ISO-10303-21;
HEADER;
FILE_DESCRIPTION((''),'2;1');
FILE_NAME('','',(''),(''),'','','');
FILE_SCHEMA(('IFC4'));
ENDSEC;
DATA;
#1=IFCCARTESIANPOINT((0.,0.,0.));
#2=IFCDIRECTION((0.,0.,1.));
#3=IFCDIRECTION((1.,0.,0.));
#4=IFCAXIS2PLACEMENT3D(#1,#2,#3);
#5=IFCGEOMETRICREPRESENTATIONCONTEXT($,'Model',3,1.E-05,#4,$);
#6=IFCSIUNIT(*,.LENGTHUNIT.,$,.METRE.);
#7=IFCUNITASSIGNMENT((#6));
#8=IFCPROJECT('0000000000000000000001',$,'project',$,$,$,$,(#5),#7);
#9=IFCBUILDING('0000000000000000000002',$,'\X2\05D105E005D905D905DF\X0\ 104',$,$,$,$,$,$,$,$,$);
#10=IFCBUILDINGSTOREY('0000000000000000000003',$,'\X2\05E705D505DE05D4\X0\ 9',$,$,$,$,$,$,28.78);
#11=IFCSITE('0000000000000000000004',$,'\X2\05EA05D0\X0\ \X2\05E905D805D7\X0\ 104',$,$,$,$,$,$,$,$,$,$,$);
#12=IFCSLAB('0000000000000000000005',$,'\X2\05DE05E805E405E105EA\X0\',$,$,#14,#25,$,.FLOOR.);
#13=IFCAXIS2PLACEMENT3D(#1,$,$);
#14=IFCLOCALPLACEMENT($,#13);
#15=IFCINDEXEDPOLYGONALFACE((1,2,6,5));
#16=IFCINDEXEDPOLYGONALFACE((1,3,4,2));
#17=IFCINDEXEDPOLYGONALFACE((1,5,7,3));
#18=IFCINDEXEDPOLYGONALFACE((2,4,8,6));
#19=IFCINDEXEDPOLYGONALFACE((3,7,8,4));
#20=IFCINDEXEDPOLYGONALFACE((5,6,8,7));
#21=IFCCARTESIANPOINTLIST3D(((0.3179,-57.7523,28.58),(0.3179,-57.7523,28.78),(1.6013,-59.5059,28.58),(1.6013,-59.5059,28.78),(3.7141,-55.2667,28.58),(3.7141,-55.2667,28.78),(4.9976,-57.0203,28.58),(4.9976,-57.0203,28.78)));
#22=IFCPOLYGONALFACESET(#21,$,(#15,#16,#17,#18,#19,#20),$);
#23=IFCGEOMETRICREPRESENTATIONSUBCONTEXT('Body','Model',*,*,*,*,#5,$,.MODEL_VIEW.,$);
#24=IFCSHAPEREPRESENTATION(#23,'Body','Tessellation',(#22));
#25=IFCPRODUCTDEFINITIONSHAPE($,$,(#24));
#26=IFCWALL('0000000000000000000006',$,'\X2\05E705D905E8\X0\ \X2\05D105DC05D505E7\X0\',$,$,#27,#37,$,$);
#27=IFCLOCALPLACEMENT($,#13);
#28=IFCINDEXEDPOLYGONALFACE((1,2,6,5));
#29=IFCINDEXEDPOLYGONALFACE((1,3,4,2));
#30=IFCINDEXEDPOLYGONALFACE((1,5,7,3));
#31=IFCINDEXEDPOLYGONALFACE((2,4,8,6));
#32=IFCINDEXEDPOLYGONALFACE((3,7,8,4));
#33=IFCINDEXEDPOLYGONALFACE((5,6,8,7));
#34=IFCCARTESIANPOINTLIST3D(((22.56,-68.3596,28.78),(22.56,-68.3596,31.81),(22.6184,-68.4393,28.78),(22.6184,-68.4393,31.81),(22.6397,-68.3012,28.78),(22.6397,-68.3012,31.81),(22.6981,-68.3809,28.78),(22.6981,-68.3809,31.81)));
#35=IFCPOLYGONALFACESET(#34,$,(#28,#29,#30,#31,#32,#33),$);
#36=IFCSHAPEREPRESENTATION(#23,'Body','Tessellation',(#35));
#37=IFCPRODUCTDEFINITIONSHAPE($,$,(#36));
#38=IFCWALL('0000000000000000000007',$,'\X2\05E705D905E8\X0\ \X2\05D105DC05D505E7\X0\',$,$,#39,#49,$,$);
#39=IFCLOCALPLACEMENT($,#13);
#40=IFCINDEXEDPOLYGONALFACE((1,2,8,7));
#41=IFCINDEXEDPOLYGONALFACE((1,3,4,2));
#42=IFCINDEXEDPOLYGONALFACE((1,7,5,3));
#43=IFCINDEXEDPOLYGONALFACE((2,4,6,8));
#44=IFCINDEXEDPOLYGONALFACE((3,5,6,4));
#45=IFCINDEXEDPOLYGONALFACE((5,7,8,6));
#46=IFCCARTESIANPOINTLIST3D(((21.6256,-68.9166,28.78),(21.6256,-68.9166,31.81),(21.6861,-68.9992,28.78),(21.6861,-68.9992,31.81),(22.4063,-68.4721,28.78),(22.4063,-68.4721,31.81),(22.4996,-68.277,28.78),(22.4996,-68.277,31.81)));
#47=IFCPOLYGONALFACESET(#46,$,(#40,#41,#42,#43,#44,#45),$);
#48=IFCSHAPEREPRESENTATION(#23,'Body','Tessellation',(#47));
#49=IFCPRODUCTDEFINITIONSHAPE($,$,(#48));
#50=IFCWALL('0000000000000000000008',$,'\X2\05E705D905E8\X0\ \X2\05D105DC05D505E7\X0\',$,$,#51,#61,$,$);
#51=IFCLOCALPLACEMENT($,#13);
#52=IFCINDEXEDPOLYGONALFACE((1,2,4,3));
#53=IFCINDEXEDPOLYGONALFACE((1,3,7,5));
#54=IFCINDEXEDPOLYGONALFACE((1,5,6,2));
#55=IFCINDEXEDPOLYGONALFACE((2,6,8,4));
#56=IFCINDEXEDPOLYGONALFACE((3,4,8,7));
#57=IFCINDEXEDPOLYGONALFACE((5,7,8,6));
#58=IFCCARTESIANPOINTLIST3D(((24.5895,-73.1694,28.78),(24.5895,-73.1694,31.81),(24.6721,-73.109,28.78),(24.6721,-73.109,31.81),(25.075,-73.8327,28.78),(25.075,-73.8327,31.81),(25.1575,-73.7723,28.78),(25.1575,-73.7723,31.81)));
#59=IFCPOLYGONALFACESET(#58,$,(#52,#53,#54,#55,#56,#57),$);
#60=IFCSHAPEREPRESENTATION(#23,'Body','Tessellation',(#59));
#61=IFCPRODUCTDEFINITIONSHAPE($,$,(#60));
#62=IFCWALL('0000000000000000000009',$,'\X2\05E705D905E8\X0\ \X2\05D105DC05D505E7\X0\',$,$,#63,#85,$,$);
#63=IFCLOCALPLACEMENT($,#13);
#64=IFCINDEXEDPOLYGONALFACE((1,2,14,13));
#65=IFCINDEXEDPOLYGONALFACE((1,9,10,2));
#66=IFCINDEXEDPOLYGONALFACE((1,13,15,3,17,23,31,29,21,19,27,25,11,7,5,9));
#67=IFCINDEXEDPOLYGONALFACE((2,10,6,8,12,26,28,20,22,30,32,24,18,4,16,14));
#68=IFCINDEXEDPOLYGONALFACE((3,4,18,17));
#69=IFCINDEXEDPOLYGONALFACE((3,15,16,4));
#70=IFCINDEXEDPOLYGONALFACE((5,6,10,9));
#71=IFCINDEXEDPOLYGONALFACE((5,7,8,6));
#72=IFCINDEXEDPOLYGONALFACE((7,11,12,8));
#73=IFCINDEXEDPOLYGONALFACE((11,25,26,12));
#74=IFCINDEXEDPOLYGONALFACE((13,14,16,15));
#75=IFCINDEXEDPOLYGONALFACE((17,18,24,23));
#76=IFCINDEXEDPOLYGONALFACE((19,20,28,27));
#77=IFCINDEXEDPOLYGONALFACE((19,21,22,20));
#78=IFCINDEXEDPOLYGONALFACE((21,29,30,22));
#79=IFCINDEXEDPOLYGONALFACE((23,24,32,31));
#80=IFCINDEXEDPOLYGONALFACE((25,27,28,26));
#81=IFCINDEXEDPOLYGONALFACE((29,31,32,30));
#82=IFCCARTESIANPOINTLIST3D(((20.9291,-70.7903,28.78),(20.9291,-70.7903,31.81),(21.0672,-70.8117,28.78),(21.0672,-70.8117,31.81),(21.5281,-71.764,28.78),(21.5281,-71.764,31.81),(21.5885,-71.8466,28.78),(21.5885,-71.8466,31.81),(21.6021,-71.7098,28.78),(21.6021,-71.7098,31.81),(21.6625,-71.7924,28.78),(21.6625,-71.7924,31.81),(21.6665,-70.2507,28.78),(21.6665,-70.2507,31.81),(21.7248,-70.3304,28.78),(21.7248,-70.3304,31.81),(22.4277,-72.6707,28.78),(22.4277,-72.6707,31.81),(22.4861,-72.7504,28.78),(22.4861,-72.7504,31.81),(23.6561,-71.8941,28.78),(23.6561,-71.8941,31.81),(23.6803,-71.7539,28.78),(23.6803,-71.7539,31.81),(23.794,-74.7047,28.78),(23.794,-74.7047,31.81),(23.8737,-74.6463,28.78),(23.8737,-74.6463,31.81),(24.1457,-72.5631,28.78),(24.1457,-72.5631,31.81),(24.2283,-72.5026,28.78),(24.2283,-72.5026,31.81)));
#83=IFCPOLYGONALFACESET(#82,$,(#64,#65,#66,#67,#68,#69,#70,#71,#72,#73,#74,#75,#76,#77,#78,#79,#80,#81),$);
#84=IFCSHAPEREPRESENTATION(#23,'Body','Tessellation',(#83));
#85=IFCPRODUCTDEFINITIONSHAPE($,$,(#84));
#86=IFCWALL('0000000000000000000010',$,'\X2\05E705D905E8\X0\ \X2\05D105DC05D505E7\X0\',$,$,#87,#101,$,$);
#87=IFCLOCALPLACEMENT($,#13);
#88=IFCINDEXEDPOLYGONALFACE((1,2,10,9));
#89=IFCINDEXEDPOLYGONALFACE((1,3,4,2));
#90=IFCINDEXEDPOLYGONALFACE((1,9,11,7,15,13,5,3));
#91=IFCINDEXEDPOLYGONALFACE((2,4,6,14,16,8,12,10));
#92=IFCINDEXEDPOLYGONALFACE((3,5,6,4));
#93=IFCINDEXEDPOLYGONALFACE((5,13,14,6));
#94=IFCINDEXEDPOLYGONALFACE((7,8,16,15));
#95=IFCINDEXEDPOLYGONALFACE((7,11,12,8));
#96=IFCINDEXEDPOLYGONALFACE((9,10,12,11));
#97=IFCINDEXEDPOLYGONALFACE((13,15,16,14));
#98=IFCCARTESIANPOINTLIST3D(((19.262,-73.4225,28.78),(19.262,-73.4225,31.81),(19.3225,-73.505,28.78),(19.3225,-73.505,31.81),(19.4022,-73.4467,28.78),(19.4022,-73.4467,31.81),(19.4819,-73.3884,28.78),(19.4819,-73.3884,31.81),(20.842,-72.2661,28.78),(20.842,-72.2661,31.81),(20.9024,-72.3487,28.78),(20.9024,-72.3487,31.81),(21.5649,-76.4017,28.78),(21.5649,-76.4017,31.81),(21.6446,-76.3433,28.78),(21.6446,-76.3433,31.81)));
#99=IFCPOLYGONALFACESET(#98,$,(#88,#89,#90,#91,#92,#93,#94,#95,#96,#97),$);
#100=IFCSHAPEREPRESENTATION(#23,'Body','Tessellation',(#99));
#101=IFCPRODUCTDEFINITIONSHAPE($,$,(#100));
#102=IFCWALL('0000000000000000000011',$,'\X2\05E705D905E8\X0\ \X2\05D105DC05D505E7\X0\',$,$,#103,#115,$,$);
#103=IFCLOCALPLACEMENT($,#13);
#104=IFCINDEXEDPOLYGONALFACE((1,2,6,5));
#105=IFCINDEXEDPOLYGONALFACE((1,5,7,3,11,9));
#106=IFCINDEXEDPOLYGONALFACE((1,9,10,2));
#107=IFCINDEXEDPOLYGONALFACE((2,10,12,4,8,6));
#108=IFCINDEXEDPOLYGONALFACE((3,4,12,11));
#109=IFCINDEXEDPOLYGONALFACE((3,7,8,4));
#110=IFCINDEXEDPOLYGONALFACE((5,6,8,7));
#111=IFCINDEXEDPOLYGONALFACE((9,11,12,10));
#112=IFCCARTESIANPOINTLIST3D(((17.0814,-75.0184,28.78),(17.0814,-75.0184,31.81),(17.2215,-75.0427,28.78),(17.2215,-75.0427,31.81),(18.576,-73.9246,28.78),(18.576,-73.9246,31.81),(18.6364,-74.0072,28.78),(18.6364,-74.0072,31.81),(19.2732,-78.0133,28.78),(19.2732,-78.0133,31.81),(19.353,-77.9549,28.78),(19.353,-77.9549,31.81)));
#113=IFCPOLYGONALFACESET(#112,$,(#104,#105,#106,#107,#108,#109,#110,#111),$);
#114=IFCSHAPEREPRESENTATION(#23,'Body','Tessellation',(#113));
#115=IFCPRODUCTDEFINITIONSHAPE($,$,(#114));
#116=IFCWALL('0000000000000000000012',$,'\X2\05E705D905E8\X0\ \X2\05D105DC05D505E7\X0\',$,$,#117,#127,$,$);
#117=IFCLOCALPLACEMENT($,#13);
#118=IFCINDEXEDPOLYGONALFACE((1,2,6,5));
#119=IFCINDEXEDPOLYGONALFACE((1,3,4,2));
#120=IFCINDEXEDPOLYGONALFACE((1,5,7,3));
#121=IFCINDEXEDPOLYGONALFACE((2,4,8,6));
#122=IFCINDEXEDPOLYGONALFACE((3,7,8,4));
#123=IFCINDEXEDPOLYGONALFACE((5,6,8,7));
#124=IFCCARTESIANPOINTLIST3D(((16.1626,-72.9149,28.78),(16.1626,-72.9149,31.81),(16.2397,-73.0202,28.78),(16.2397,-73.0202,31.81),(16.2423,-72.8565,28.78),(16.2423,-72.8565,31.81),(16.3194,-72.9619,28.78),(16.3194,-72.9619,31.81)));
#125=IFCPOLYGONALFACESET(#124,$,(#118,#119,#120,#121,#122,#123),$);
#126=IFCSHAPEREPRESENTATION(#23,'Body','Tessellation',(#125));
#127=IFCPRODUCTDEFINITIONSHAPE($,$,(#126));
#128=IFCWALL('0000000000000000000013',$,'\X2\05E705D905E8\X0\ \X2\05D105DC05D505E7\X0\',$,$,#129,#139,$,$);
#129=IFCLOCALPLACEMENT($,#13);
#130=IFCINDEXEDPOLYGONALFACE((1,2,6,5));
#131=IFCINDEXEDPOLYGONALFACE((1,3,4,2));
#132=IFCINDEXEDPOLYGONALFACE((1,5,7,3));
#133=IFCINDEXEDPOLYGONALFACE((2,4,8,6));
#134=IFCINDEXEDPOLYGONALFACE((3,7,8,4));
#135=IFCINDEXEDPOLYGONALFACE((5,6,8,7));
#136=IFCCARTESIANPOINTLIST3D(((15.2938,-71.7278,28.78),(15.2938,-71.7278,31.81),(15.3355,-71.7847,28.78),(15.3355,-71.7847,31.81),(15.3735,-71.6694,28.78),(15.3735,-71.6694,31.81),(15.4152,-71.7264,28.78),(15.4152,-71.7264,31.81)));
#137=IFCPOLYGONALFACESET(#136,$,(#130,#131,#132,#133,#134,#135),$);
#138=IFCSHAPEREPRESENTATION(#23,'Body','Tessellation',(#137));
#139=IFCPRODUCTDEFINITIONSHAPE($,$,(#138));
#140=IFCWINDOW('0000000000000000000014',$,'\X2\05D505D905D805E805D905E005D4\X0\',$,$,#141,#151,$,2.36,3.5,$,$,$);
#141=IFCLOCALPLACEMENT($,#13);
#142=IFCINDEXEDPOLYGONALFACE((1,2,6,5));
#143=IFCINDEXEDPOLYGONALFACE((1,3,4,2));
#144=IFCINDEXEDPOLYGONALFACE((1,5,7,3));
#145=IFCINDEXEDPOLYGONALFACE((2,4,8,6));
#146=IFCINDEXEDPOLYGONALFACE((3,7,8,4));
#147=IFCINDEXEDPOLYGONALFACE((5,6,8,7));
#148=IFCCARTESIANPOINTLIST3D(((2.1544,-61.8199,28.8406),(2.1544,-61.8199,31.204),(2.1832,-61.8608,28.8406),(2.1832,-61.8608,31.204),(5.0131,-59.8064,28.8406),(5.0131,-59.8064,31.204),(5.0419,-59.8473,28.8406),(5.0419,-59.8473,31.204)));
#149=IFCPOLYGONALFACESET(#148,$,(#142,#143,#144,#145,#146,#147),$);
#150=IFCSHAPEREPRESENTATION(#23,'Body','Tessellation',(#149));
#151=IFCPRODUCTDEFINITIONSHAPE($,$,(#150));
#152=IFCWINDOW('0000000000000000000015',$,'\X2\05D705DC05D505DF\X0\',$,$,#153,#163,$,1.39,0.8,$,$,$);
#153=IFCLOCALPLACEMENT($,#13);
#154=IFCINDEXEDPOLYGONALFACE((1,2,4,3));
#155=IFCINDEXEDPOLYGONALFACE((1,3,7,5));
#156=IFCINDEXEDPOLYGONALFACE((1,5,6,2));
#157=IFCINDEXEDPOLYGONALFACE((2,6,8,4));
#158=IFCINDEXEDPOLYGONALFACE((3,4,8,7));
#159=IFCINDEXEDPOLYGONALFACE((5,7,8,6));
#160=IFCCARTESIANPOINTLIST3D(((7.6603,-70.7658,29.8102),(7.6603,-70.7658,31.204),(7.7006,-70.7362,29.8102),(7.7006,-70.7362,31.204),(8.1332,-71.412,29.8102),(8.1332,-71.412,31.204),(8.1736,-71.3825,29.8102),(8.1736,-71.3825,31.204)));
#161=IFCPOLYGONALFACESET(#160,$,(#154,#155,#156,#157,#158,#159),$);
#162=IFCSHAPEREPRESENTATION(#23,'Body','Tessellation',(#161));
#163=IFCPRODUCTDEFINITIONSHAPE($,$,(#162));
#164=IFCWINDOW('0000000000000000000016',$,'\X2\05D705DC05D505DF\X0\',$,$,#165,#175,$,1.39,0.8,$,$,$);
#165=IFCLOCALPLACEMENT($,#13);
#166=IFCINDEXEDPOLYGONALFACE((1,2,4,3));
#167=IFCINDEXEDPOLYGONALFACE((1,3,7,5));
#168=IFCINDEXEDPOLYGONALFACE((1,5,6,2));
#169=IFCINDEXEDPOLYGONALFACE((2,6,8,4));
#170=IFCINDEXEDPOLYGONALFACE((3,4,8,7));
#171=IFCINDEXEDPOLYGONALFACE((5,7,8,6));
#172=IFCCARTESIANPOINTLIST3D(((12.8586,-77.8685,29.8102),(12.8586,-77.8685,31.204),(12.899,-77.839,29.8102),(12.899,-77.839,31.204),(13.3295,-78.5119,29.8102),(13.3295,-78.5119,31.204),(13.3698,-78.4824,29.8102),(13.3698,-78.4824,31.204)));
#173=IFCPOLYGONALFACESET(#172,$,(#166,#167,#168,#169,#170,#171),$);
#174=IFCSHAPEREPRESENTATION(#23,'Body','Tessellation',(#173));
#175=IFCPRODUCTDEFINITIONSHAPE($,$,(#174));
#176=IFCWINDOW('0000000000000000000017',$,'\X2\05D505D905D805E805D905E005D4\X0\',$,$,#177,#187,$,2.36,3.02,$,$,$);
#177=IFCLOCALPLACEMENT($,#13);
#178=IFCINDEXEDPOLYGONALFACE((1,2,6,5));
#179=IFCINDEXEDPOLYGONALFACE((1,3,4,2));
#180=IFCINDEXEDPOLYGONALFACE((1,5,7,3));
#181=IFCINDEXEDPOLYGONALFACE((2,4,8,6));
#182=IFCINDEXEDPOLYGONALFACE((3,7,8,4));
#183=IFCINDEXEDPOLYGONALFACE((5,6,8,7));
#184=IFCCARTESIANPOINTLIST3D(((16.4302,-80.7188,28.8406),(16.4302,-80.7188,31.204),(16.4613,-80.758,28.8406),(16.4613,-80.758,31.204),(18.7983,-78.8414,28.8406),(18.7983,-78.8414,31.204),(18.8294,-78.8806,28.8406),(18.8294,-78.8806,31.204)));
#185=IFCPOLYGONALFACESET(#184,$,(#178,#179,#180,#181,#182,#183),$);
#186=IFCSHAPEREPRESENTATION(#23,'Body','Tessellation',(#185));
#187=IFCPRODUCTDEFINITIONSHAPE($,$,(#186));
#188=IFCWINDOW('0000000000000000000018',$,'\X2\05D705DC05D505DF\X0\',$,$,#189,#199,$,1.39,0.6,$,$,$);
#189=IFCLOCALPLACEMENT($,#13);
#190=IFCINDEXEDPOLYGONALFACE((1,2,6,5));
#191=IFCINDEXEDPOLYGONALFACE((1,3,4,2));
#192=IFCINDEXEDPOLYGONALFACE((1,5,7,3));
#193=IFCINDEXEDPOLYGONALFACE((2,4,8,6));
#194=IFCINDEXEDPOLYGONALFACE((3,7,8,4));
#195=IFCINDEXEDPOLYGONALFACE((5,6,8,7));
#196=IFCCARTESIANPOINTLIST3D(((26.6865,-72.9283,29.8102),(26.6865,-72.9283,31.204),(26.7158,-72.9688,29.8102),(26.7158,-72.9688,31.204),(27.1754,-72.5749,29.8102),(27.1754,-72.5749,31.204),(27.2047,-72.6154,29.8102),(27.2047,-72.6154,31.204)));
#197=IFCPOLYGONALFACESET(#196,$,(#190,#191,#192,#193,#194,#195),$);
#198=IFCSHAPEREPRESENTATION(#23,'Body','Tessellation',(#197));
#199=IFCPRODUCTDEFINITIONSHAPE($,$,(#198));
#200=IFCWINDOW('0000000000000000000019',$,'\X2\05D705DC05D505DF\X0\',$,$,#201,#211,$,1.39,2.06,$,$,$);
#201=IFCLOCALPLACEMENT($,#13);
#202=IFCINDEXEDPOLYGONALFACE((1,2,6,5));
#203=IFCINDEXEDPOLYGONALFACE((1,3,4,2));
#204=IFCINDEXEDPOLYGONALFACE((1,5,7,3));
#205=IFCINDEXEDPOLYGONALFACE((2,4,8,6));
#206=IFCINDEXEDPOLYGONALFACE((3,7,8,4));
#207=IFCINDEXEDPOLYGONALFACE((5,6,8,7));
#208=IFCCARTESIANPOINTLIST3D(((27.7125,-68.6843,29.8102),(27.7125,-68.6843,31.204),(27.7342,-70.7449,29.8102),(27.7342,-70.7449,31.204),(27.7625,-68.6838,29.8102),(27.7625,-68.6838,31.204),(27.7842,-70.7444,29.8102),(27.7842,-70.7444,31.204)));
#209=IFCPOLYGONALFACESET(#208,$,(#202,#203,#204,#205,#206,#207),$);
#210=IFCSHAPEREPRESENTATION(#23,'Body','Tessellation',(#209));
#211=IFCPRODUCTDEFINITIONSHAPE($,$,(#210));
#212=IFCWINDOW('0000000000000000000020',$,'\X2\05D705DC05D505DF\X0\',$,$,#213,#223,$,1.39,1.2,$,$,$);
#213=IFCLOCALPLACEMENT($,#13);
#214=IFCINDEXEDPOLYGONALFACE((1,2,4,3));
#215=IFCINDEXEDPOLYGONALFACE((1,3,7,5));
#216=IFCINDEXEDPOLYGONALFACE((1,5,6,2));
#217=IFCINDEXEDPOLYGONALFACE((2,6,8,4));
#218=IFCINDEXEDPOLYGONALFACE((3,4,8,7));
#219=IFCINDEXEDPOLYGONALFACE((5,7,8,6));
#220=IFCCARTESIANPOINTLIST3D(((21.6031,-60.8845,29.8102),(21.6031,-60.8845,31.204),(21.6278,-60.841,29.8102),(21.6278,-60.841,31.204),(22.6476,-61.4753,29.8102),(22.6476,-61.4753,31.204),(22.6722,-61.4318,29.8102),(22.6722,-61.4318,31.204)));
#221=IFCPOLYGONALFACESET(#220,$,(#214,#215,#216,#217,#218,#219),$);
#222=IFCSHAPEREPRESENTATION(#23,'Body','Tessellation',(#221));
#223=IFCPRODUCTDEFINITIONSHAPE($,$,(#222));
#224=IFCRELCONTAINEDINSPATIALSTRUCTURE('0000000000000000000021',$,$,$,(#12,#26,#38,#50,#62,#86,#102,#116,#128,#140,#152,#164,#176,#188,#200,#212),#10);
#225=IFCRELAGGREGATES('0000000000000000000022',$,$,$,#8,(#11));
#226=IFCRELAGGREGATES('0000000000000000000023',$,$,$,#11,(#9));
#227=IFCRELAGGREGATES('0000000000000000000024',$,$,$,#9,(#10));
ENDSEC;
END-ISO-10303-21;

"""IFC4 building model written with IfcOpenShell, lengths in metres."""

from ifc_helpers import new_model, si_unit, frame, origin_with_axes, context, subcontext, project, spatial, polyline, outline, extrude, element, save


model = new_model("IFC4")

# Units and contexts
model_context = context("Model", 3, precision=1e-05, world=origin_with_axes())
body_context = subcontext(model_context, "Body", "Model", "MODEL_VIEW")
ifc_project = project(units=[si_unit("LENGTHUNIT", "METRE")], contexts=[model_context])

# Site, building, storey
site = spatial("IfcSite", under=ifc_project, Name="תא שטח 104")
building = spatial("IfcBuilding", under=site, Name="בניין 104")
storey = spatial("IfcBuildingStorey", under=building, Name="קומה 9", Elevation=28.78)

# Slab
element("IfcSlab", 1, inside=storey, Name="מרפסת", PredefinedType="FLOOR", context=body_context, shape_type="SweptSolid", body=[
    extrude(outline(polyline([(3.7141, -55.2667), (4.9976, -57.0203), (1.6013, -59.5059), (0.3179, -57.7523), (3.7141, -55.2667)])), frame((0.0, 0.0, 28.58)), (0.0, 0.0, 1.0), 0.2),
])

# Walls
element("IfcWall", 2, inside=storey, Name="קיר בלוק", context=body_context, shape_type="SweptSolid", body=[
    extrude(outline(polyline([(22.6184, -68.4393), (22.6981, -68.3809), (22.6397, -68.3012), (22.56, -68.3596), (22.6184, -68.4393)])), frame((0.0, 0.0, 28.78)), (0.0, 0.0, 1.0), 3.03),
])
element("IfcWall", 3, inside=storey, Name="קיר בלוק", context=body_context, shape_type="SweptSolid", body=[
    extrude(outline(polyline([(22.4996, -68.277), (21.6256, -68.9166), (21.6861, -68.9992), (22.4063, -68.4721), (22.4996, -68.277)])), frame((0.0, 0.0, 28.78)), (0.0, 0.0, 1.0), 3.03),
])
element("IfcWall", 4, inside=storey, Name="קיר בלוק", context=body_context, shape_type="SweptSolid", body=[
    extrude(outline(polyline([(25.075, -73.8327), (25.1575, -73.7723), (24.6721, -73.109), (24.5895, -73.1694), (25.075, -73.8327)])), frame((0.0, 0.0, 28.78)), (0.0, 0.0, 1.0), 3.03),
])
element("IfcWall", 5, inside=storey, Name="קיר בלוק", context=body_context, shape_type="SweptSolid", body=[
    extrude(outline(polyline([(21.0672, -70.8117), (21.7248, -70.3304), (21.6665, -70.2507), (20.9291, -70.7903), (21.6021, -71.7098), (21.5281, -71.764), (21.5885, -71.8466), (21.6625, -71.7924), (23.794, -74.7047), (23.8737, -74.6463), (22.4861, -72.7504), (23.6561, -71.8941), (24.1457, -72.5631), (24.2283, -72.5026), (23.6803, -71.7539), (22.4277, -72.6707), (21.0672, -70.8117)])), frame((0.0, 0.0, 28.78)), (0.0, 0.0, 1.0), 3.03),
])
element("IfcWall", 6, inside=storey, Name="קיר בלוק", context=body_context, shape_type="SweptSolid", body=[
    extrude(outline(polyline([(19.3225, -73.505), (19.4022, -73.4467), (21.5649, -76.4017), (21.6446, -76.3433), (19.4819, -73.3884), (20.9024, -72.3487), (20.842, -72.2661), (19.262, -73.4225), (19.3225, -73.505)])), frame((0.0, 0.0, 28.78)), (0.0, 0.0, 1.0), 3.03),
])
element("IfcWall", 7, inside=storey, Name="קיר בלוק", context=body_context, shape_type="SweptSolid", body=[
    extrude(outline(polyline([(17.0814, -75.0184), (19.2732, -78.0133), (19.353, -77.9549), (17.2215, -75.0427), (18.6364, -74.0072), (18.576, -73.9246), (17.0814, -75.0184)])), frame((0.0, 0.0, 28.78)), (0.0, 0.0, 1.0), 3.03),
])
element("IfcWall", 8, inside=storey, Name="קיר בלוק", context=body_context, shape_type="SweptSolid", body=[
    extrude(outline(polyline([(16.3194, -72.9619), (16.2423, -72.8565), (16.1626, -72.9149), (16.2397, -73.0202), (16.3194, -72.9619)])), frame((0.0, 0.0, 28.78)), (0.0, 0.0, 1.0), 3.03),
])
element("IfcWall", 9, inside=storey, Name="קיר בלוק", context=body_context, shape_type="SweptSolid", body=[
    extrude(outline(polyline([(15.2938, -71.7278), (15.3355, -71.7847), (15.4152, -71.7264), (15.3735, -71.6694), (15.2938, -71.7278)])), frame((0.0, 0.0, 28.78)), (0.0, 0.0, 1.0), 3.03),
])

# Windows
element("IfcWindow", 10, inside=storey, Name="ויטרינה", OverallHeight=2.36, OverallWidth=3.5, context=body_context, shape_type="SweptSolid", body=[
    extrude(outline(polyline([(5.0131, -59.8064), (2.1544, -61.8199), (2.1832, -61.8608), (5.0419, -59.8473), (5.0131, -59.8064)])), frame((0.0, 0.0, 28.8406)), (0.0, 0.0, 1.0), 2.3634),
])
element("IfcWindow", 11, inside=storey, Name="חלון", OverallHeight=1.39, OverallWidth=0.8, context=body_context, shape_type="SweptSolid", body=[
    extrude(outline(polyline([(7.6603, -70.7658), (8.1332, -71.412), (8.1736, -71.3825), (7.7006, -70.7362), (7.6603, -70.7658)])), frame((0.0, 0.0, 29.8102)), (0.0, 0.0, 1.0), 1.3938),
])
element("IfcWindow", 12, inside=storey, Name="חלון", OverallHeight=1.39, OverallWidth=0.8, context=body_context, shape_type="SweptSolid", body=[
    extrude(outline(polyline([(12.8586, -77.8685), (13.3295, -78.5119), (13.3698, -78.4824), (12.899, -77.839), (12.8586, -77.8685)])), frame((0.0, 0.0, 29.8102)), (0.0, 0.0, 1.0), 1.3938),
])
element("IfcWindow", 13, inside=storey, Name="ויטרינה", OverallHeight=2.36, OverallWidth=3.02, context=body_context, shape_type="SweptSolid", body=[
    extrude(outline(polyline([(16.4613, -80.758), (18.8294, -78.8806), (18.7983, -78.8414), (16.4302, -80.7188), (16.4613, -80.758)])), frame((0.0, 0.0, 28.8406)), (0.0, 0.0, 1.0), 2.3634),
])
element("IfcWindow", 14, inside=storey, Name="חלון", OverallHeight=1.39, OverallWidth=0.6, context=body_context, shape_type="SweptSolid", body=[
    extrude(outline(polyline([(26.7158, -72.9688), (27.2047, -72.6154), (27.1754, -72.5749), (26.6865, -72.9283), (26.7158, -72.9688)])), frame((0.0, 0.0, 29.8102)), (0.0, 0.0, 1.0), 1.3938),
])
element("IfcWindow", 15, inside=storey, Name="חלון", OverallHeight=1.39, OverallWidth=2.06, context=body_context, shape_type="SweptSolid", body=[
    extrude(outline(polyline([(27.7842, -70.7444), (27.7625, -68.6838), (27.7125, -68.6843), (27.7342, -70.7449), (27.7842, -70.7444)])), frame((0.0, 0.0, 29.8102)), (0.0, 0.0, 1.0), 1.3938),
])
element("IfcWindow", 16, inside=storey, Name="חלון", OverallHeight=1.39, OverallWidth=1.2, context=body_context, shape_type="SweptSolid", body=[
    extrude(outline(polyline([(22.6722, -61.4318), (21.6278, -60.841), (21.6031, -60.8845), (22.6476, -61.4753), (22.6722, -61.4318)])), frame((0.0, 0.0, 29.8102)), (0.0, 0.0, 1.0), 1.3938),
])

save(model, "model.ifc")
